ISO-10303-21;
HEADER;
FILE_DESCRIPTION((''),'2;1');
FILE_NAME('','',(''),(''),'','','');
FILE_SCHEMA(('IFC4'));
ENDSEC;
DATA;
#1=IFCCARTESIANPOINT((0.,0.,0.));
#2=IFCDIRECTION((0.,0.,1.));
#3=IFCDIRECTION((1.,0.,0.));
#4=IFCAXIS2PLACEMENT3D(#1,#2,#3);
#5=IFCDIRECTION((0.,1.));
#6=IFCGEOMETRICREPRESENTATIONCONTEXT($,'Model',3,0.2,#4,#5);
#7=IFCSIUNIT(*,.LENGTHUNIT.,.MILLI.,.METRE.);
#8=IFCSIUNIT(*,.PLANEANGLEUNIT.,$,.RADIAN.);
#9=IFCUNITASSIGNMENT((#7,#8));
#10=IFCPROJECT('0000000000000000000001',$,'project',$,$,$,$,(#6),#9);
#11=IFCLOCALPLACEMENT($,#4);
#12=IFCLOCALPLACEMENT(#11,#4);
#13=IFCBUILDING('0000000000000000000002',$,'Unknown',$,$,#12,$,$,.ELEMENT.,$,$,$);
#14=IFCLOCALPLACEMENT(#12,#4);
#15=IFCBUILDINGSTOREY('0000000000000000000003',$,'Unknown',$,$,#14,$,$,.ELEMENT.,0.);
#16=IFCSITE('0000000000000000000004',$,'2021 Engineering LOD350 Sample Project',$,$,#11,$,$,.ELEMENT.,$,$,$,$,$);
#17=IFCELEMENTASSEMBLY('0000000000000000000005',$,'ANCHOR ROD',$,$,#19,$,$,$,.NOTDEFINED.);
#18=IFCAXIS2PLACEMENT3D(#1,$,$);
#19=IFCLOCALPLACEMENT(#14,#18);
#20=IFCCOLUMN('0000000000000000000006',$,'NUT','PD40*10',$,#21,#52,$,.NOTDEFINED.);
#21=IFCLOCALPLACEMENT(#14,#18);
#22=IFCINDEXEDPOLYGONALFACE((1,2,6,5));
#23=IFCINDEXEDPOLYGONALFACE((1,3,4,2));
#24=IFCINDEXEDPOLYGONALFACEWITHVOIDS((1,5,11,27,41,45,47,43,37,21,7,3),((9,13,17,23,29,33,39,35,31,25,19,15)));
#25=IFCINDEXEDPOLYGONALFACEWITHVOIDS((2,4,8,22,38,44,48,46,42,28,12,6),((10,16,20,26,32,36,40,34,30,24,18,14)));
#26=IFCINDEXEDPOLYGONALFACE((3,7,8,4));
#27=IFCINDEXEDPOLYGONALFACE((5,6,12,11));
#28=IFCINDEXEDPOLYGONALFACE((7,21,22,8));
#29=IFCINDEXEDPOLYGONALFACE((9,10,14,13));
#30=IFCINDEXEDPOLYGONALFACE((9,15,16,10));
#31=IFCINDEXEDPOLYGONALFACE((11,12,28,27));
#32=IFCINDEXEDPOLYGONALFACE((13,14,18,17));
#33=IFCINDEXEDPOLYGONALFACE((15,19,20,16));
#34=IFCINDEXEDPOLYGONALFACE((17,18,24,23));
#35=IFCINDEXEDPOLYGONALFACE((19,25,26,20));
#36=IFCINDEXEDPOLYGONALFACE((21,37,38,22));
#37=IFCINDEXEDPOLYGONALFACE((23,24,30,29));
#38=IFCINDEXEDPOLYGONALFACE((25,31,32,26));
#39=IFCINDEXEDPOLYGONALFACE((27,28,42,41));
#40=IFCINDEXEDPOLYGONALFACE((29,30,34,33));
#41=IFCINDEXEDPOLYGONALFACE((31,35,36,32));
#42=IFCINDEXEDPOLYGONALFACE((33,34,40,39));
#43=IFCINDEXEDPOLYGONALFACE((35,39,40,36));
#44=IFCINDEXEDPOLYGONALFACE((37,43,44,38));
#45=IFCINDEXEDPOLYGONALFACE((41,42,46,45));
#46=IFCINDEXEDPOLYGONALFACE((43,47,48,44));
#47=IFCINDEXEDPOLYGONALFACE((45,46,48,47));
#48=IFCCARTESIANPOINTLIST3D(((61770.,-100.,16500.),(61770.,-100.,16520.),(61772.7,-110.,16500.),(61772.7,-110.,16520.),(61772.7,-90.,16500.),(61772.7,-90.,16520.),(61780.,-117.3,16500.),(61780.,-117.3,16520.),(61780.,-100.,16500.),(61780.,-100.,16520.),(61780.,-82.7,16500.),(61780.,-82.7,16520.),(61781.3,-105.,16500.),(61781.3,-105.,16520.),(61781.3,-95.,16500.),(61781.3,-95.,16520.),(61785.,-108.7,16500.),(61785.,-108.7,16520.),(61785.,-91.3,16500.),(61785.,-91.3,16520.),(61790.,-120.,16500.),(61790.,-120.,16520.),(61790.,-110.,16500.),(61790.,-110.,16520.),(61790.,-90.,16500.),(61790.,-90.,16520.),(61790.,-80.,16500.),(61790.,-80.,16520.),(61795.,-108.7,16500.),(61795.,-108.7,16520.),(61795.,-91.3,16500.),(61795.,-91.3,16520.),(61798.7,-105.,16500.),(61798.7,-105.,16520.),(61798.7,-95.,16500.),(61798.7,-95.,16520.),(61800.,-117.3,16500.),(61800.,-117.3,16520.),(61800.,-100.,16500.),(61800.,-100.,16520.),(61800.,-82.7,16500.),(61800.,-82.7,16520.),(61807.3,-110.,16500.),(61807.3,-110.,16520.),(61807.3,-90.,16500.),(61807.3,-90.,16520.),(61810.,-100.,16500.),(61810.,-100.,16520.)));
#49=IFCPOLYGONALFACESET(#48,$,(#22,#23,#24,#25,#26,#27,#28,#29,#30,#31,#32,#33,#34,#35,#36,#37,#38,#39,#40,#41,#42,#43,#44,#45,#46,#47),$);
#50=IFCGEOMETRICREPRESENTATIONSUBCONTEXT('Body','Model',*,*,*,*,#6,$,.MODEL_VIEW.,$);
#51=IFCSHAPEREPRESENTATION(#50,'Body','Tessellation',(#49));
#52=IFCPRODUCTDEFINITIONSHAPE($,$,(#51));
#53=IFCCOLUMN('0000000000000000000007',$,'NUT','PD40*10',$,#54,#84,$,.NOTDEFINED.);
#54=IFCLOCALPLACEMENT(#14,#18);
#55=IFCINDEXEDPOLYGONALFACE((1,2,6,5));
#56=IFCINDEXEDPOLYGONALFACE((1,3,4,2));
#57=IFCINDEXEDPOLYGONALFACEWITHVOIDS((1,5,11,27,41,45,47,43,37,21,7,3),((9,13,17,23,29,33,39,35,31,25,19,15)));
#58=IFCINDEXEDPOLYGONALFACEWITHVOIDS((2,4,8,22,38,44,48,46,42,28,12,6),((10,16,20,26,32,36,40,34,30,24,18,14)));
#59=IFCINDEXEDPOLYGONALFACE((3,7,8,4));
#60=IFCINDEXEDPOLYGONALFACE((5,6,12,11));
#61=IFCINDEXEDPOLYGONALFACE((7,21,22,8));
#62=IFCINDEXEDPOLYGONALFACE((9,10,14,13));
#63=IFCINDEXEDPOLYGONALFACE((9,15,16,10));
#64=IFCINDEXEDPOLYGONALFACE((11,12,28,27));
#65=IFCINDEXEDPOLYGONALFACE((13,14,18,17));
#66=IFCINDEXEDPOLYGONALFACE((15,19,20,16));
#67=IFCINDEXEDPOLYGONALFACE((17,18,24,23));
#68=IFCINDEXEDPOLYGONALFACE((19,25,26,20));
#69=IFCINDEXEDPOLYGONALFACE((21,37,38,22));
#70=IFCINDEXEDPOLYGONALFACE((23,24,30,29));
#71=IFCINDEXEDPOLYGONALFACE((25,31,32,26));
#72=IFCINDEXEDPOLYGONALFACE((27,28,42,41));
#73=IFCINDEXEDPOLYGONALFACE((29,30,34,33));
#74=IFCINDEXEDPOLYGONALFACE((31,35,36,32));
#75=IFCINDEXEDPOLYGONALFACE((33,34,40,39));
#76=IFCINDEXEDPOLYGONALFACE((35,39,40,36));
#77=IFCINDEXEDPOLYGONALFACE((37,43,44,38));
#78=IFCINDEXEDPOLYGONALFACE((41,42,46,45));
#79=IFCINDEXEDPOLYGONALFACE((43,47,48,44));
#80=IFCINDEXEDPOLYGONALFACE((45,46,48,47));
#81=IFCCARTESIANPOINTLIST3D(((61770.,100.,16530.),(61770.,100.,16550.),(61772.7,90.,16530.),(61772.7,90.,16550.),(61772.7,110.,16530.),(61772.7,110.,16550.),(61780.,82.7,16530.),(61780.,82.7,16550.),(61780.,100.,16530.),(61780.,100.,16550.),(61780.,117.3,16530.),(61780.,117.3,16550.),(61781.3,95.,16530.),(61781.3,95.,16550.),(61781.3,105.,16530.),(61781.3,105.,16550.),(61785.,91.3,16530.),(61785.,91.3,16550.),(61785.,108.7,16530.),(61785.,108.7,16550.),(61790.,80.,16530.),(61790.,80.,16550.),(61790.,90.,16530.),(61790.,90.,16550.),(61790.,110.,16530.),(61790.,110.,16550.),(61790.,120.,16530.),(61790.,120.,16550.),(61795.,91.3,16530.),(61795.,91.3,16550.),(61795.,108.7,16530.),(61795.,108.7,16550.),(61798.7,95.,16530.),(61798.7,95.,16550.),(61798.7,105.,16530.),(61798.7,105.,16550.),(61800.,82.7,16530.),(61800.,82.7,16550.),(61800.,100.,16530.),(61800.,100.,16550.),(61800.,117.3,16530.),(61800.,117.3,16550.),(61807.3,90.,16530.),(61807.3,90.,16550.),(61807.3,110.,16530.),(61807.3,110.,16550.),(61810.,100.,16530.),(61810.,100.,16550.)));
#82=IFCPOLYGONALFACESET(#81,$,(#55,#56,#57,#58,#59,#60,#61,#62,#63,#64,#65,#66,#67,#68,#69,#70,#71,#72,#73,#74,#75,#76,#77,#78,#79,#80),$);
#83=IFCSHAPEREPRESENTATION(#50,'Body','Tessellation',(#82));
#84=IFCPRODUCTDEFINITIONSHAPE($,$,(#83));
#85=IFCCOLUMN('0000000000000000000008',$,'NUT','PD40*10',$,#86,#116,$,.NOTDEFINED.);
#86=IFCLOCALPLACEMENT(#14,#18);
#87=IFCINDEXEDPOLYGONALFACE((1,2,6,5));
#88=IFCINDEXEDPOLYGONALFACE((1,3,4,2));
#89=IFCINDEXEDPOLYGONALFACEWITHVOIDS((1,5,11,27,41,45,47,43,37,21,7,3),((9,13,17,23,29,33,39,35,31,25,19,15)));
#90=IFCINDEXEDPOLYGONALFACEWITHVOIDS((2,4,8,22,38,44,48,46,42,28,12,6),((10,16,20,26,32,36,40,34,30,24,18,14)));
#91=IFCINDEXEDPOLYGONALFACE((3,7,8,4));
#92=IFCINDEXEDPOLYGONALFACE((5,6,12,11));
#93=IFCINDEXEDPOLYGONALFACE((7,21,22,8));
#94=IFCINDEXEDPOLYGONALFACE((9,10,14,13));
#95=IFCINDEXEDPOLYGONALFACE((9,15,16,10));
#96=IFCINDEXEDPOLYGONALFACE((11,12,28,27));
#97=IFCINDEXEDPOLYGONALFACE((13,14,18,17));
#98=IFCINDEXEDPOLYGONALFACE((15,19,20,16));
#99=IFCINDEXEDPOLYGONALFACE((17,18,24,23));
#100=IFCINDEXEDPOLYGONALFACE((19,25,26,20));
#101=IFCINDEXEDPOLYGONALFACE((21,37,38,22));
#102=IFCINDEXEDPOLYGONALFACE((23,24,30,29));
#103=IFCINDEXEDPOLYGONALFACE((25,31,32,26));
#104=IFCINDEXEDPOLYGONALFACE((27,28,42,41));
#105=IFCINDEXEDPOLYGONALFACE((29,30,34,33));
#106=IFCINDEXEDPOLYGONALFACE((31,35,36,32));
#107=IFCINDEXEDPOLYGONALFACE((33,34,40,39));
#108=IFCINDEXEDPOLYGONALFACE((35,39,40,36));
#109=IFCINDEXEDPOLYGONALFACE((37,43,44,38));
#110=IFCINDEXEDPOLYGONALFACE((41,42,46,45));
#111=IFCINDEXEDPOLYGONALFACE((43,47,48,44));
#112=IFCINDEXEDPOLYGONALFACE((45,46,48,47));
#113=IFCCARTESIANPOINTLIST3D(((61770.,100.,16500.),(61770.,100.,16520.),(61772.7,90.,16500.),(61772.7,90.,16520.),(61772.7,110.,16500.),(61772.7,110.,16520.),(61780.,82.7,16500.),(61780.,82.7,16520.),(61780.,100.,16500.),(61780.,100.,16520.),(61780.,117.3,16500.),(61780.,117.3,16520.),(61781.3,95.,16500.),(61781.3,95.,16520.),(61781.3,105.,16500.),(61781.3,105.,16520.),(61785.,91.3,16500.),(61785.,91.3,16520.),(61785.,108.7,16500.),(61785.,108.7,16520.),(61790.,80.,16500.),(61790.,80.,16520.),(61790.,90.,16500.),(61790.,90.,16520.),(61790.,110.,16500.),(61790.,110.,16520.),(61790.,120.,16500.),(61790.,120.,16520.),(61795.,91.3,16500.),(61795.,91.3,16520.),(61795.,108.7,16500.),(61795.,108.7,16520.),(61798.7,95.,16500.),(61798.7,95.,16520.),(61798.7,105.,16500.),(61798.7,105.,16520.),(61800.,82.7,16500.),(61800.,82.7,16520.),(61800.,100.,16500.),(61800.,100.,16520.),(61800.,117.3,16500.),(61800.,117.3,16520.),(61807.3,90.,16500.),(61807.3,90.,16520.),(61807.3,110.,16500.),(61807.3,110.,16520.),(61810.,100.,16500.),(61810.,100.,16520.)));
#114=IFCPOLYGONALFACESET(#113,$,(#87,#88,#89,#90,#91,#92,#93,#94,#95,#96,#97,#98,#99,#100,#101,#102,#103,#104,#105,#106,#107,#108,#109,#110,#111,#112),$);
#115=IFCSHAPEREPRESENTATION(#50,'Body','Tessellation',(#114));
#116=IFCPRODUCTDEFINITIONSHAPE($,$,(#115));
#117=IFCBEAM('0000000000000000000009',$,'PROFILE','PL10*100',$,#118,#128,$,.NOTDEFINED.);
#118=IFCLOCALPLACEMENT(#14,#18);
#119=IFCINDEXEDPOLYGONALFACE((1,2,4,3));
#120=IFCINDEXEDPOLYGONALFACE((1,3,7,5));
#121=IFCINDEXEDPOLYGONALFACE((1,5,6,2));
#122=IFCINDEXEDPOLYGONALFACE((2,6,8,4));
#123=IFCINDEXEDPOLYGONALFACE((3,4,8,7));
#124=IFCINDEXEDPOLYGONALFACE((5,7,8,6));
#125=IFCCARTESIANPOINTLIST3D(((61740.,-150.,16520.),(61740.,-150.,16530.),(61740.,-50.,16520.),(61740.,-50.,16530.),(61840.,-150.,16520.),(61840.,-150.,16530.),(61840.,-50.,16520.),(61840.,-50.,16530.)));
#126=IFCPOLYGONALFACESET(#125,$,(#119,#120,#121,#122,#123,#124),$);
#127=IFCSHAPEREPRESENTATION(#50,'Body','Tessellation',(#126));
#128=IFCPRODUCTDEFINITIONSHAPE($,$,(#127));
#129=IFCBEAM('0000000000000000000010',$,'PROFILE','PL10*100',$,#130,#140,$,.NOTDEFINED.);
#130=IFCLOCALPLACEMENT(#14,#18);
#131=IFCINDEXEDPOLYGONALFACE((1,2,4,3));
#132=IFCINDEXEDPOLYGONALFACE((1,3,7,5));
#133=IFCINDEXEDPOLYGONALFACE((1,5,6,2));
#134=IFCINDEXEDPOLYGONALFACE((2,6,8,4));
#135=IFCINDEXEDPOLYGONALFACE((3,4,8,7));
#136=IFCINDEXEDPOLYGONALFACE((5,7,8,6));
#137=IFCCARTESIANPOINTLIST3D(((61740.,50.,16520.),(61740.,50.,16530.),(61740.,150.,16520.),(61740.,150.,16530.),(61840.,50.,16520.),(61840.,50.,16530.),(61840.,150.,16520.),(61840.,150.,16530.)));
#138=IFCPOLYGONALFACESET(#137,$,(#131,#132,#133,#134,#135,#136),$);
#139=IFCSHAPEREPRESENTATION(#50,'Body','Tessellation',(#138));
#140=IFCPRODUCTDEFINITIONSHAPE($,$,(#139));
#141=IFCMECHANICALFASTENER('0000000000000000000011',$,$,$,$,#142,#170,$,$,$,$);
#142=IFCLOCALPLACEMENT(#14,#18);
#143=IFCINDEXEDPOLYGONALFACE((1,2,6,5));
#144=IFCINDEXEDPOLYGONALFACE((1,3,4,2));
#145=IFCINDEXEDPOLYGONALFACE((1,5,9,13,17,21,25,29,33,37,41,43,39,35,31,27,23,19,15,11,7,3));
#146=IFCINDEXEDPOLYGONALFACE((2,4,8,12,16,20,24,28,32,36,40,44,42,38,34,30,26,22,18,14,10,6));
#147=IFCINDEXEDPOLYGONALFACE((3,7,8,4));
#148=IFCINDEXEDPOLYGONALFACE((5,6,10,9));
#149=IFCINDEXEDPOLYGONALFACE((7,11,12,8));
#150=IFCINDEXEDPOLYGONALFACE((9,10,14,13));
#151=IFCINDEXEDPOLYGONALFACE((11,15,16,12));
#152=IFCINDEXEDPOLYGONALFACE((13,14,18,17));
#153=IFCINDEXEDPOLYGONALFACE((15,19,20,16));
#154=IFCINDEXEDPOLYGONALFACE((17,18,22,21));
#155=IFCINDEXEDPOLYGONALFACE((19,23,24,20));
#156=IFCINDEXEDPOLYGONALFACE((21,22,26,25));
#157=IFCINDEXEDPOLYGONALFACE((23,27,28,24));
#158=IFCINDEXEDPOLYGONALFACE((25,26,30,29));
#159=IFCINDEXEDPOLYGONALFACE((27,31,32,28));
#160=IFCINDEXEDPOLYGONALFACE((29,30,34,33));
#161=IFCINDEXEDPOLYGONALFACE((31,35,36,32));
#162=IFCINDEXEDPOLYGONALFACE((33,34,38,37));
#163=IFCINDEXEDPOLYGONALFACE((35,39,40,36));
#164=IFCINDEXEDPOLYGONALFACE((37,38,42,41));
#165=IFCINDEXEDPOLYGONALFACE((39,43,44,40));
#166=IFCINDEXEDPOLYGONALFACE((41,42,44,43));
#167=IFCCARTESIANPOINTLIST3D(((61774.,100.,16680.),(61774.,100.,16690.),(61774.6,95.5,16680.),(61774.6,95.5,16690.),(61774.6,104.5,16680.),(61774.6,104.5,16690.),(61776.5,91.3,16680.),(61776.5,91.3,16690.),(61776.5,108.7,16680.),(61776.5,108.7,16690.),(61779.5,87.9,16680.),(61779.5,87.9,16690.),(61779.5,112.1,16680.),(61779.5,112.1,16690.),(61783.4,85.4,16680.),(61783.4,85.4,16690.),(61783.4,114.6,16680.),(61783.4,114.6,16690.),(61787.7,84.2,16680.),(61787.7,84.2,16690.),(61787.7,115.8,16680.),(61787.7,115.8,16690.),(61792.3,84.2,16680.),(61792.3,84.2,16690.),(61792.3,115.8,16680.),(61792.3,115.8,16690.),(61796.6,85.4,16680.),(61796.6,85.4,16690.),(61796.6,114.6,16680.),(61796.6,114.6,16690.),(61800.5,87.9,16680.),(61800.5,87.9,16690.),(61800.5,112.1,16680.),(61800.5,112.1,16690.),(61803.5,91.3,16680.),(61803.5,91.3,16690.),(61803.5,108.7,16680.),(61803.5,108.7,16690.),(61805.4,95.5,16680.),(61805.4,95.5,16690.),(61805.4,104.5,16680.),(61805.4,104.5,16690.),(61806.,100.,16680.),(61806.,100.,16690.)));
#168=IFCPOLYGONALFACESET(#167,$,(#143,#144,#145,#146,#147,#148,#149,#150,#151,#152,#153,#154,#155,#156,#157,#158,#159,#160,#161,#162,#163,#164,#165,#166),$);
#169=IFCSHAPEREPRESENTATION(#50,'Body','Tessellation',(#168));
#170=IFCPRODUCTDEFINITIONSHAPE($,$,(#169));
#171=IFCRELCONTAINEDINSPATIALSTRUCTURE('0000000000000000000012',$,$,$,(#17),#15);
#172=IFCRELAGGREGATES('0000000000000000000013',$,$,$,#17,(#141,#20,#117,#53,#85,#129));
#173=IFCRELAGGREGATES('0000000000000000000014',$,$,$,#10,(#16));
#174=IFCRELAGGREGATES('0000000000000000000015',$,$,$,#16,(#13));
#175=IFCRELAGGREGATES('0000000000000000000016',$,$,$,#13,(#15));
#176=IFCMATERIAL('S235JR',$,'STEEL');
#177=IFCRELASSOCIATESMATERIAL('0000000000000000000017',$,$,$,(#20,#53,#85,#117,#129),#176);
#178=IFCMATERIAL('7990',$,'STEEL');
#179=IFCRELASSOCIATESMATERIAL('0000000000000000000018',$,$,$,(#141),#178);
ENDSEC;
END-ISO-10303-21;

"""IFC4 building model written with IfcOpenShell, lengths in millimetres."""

from ifc_helpers import new_model, si_unit, direction, frame, origin_with_axes, place, context, subcontext, project, spatial, line, arc, indexed_curve, outline, extrude, source, transform, mapped, material, element, aggregate, save


model = new_model("IFC4")

# Units and contexts
model_context = context("Model", 3, precision=0.2, world=origin_with_axes(), true_north=direction((0.0, 1.0)))
body_context = subcontext(model_context, "Body", "Model", "MODEL_VIEW")
ifc_project = project(units=[si_unit("LENGTHUNIT", "METRE", prefix="MILLI"), si_unit("PLANEANGLEUNIT", "RADIAN")], contexts=[model_context])

# Site, building, storey
site_placement = place(None, origin_with_axes())
site = spatial("IfcSite", under=ifc_project, at=site_placement, Name="2021 Engineering LOD350 Sample Project", CompositionType="ELEMENT")
building_placement = place(site_placement, origin_with_axes())
building = spatial("IfcBuilding", under=site, at=building_placement, Name="Unknown", CompositionType="ELEMENT")
storey_placement = place(building_placement, origin_with_axes())
storey = spatial("IfcBuildingStorey", under=building, at=storey_placement, Name="Unknown", CompositionType="ELEMENT", Elevation=0.0)

# Shared definitions
ifc_material_1 = material(Name="S235JR", Category="STEEL")

# Element assembly, columns
assembly_1_placement = place(storey_placement, frame((61790.0, 100.0, 16730.0), z_axis=(1.0, 0.0, 0.0), x_axis=(0.0, 0.0, -1.0)))
assembly_1 = element("IfcElementAssembly", 1, at=assembly_1_placement, inside=storey, Name="ANCHOR ROD", PredefinedType="NOTDEFINED")
column_1_placement = place(assembly_1_placement, frame((210.0, -200.0, 0.0), z_axis=(0.0, 0.0, 1.0), x_axis=(1.0, 0.0, 0.0)))
column_1 = element("IfcColumn", 2, at=column_1_placement, material=ifc_material_1, Name="NUT", Description="PD40*10", PredefinedType="NOTDEFINED", context=body_context, shape_type="SolidModel", body=[
    extrude(outline(indexed_curve([(20.0, 0.0), (17.3, 10.0), (10.0, 17.3), (0.0, 20.0), (-10.0, 17.3), (-17.3, 10.0), (-20.0, 0.0), (-17.3, -10.0), (-10.0, -17.3), (0.0, -20.0), (10.0, -17.3), (17.3, -10.0)], segments=[line(1, 2, 3, 4, 5, 6, 7, 8, 9, 10, 11, 12, 1)]), holes=[indexed_curve([(10.0, 0.0), (8.7, -5.0), (5.0, -8.7), (0.0, -10.0), (-5.0, -8.7), (-8.7, -5.0), (-10.0, 0.0), (-8.7, 5.0), (-5.0, 8.7), (0.0, 10.0), (5.0, 8.7), (8.7, 5.0)], segments=[line(1, 2, 3, 4, 5, 6, 7, 8, 9, 10, 11, 12, 1)])]), frame((0.0, 0.0, 0.0), z_axis=(-1.0, 0.0, 0.0), x_axis=(0.0, 0.0, 1.0)), (0.0, 0.0, -1.0), 20.0),
])
column_2_placement = place(assembly_1_placement, frame((180.0, 0.0, 0.0), z_axis=(0.0, 0.0, 1.0), x_axis=(1.0, 0.0, 0.0)))
column_2 = element("IfcColumn", 3, at=column_2_placement, material=ifc_material_1, Name="NUT", Description="PD40*10", PredefinedType="NOTDEFINED", context=body_context, shape_type="SolidModel", body=[
    extrude(outline(indexed_curve([(20.0, 0.0), (17.3, 10.0), (10.0, 17.3), (0.0, 20.0), (-10.0, 17.3), (-17.3, 10.0), (-20.0, 0.0), (-17.3, -10.0), (-10.0, -17.3), (0.0, -20.0), (10.0, -17.3), (17.3, -10.0)], segments=[line(1, 2, 3, 4, 5, 6, 7, 8, 9, 10, 11, 12, 1)]), holes=[indexed_curve([(10.0, 0.0), (8.7, -5.0), (5.0, -8.7), (0.0, -10.0), (-5.0, -8.7), (-8.7, -5.0), (-10.0, 0.0), (-8.7, 5.0), (-5.0, 8.7), (0.0, 10.0), (5.0, 8.7), (8.7, 5.0)], segments=[line(1, 2, 3, 4, 5, 6, 7, 8, 9, 10, 11, 12, 1)])]), frame((0.0, 0.0, 0.0), z_axis=(-1.0, 0.0, 0.0), x_axis=(0.0, 0.0, 1.0)), (0.0, 0.0, -1.0), 20.0),
])
column_3_placement = place(assembly_1_placement, frame((210.0, 0.0, 0.0), z_axis=(0.0, 0.0, 1.0), x_axis=(1.0, 0.0, 0.0)))
column_3 = element("IfcColumn", 4, at=column_3_placement, material=ifc_material_1, Name="NUT", Description="PD40*10", PredefinedType="NOTDEFINED", context=body_context, shape_type="SolidModel", body=[
    extrude(outline(indexed_curve([(20.0, 0.0), (17.3, 10.0), (10.0, 17.3), (0.0, 20.0), (-10.0, 17.3), (-17.3, 10.0), (-20.0, 0.0), (-17.3, -10.0), (-10.0, -17.3), (0.0, -20.0), (10.0, -17.3), (17.3, -10.0)], segments=[line(1, 2, 3, 4, 5, 6, 7, 8, 9, 10, 11, 12, 1)]), holes=[indexed_curve([(10.0, 0.0), (8.7, -5.0), (5.0, -8.7), (0.0, -10.0), (-5.0, -8.7), (-8.7, -5.0), (-10.0, 0.0), (-8.7, 5.0), (-5.0, 8.7), (0.0, 10.0), (5.0, 8.7), (8.7, 5.0)], segments=[line(1, 2, 3, 4, 5, 6, 7, 8, 9, 10, 11, 12, 1)])]), frame((0.0, 0.0, 0.0), z_axis=(-1.0, 0.0, 0.0), x_axis=(0.0, 0.0, 1.0)), (0.0, 0.0, -1.0), 20.0),
])

# Beams
beam_1_placement = place(assembly_1_placement, frame((205.0, -250.0, 0.0), z_axis=(1.0, 0.0, 0.0), x_axis=(0.0, 1.0, 0.0)))
beam_1 = element("IfcBeam", 5, at=beam_1_placement, material=ifc_material_1, Name="PROFILE", Description="PL10*100", PredefinedType="NOTDEFINED", context=body_context, shape_type="SolidModel", body=[
    extrude(outline(indexed_curve([(-5.0, -50.0), (5.0, -50.0), (5.0, 50.0), (-5.0, 50.0)], segments=[line(1, 2, 3, 4, 1)])), frame((0.0, 0.0, 0.0), z_axis=(-1.0, 0.0, 0.0), x_axis=(0.0, 0.0, 1.0)), (0.0, 0.0, -1.0), 100.0),
])
beam_2_placement = place(assembly_1_placement, frame((205.0, -50.0, 0.0), z_axis=(1.0, 0.0, 0.0), x_axis=(0.0, 1.0, 0.0)))
beam_2 = element("IfcBeam", 6, at=beam_2_placement, material=ifc_material_1, Name="PROFILE", Description="PL10*100", PredefinedType="NOTDEFINED", context=body_context, shape_type="SolidModel", body=[
    extrude(outline(indexed_curve([(-5.0, -50.0), (5.0, -50.0), (5.0, 50.0), (-5.0, 50.0)], segments=[line(1, 2, 3, 4, 1)])), frame((0.0, 0.0, 0.0), z_axis=(-1.0, 0.0, 0.0), x_axis=(0.0, 0.0, 1.0)), (0.0, 0.0, -1.0), 100.0),
])

# Shared definitions
ifc_material_2 = material(Name="7990", Category="STEEL")

# Mechanical fastener
shared_shape_1 = source(origin_with_axes(), body_context, "Body", "SweptSolid", [
    extrude(outline(indexed_curve([(16.0, 0.0), (0.0, 16.0), (-16.0, 0.0), (0.0, -16.0)], segments=[arc(1, 2, 3), arc(3, 4, 1)])), frame((0.0, 0.0, 0.0), z_axis=(0.0, 0.0, -1.0), x_axis=(0.0, 1.0, 0.0)), (0.0, 0.0, 1.0), 10.0),
])
mechanical_fastener_1_placement = place(assembly_1_placement, frame((50.0, 0.0, 0.0), z_axis=(1.0, 0.0, 0.0), x_axis=(0.0, 1.0, 0.0)))
mechanical_fastener_1 = element("IfcMechanicalFastener", 7, at=mechanical_fastener_1_placement, material=ifc_material_2, context=body_context, shape_type="MappedRepresentation", body=[
    mapped(shared_shape_1, transform((0.0, 0.0, 0.0))),
])
aggregate(assembly_1, [mechanical_fastener_1, column_1, beam_1, column_2, column_3, beam_2])

save(model, "model.ifc")
